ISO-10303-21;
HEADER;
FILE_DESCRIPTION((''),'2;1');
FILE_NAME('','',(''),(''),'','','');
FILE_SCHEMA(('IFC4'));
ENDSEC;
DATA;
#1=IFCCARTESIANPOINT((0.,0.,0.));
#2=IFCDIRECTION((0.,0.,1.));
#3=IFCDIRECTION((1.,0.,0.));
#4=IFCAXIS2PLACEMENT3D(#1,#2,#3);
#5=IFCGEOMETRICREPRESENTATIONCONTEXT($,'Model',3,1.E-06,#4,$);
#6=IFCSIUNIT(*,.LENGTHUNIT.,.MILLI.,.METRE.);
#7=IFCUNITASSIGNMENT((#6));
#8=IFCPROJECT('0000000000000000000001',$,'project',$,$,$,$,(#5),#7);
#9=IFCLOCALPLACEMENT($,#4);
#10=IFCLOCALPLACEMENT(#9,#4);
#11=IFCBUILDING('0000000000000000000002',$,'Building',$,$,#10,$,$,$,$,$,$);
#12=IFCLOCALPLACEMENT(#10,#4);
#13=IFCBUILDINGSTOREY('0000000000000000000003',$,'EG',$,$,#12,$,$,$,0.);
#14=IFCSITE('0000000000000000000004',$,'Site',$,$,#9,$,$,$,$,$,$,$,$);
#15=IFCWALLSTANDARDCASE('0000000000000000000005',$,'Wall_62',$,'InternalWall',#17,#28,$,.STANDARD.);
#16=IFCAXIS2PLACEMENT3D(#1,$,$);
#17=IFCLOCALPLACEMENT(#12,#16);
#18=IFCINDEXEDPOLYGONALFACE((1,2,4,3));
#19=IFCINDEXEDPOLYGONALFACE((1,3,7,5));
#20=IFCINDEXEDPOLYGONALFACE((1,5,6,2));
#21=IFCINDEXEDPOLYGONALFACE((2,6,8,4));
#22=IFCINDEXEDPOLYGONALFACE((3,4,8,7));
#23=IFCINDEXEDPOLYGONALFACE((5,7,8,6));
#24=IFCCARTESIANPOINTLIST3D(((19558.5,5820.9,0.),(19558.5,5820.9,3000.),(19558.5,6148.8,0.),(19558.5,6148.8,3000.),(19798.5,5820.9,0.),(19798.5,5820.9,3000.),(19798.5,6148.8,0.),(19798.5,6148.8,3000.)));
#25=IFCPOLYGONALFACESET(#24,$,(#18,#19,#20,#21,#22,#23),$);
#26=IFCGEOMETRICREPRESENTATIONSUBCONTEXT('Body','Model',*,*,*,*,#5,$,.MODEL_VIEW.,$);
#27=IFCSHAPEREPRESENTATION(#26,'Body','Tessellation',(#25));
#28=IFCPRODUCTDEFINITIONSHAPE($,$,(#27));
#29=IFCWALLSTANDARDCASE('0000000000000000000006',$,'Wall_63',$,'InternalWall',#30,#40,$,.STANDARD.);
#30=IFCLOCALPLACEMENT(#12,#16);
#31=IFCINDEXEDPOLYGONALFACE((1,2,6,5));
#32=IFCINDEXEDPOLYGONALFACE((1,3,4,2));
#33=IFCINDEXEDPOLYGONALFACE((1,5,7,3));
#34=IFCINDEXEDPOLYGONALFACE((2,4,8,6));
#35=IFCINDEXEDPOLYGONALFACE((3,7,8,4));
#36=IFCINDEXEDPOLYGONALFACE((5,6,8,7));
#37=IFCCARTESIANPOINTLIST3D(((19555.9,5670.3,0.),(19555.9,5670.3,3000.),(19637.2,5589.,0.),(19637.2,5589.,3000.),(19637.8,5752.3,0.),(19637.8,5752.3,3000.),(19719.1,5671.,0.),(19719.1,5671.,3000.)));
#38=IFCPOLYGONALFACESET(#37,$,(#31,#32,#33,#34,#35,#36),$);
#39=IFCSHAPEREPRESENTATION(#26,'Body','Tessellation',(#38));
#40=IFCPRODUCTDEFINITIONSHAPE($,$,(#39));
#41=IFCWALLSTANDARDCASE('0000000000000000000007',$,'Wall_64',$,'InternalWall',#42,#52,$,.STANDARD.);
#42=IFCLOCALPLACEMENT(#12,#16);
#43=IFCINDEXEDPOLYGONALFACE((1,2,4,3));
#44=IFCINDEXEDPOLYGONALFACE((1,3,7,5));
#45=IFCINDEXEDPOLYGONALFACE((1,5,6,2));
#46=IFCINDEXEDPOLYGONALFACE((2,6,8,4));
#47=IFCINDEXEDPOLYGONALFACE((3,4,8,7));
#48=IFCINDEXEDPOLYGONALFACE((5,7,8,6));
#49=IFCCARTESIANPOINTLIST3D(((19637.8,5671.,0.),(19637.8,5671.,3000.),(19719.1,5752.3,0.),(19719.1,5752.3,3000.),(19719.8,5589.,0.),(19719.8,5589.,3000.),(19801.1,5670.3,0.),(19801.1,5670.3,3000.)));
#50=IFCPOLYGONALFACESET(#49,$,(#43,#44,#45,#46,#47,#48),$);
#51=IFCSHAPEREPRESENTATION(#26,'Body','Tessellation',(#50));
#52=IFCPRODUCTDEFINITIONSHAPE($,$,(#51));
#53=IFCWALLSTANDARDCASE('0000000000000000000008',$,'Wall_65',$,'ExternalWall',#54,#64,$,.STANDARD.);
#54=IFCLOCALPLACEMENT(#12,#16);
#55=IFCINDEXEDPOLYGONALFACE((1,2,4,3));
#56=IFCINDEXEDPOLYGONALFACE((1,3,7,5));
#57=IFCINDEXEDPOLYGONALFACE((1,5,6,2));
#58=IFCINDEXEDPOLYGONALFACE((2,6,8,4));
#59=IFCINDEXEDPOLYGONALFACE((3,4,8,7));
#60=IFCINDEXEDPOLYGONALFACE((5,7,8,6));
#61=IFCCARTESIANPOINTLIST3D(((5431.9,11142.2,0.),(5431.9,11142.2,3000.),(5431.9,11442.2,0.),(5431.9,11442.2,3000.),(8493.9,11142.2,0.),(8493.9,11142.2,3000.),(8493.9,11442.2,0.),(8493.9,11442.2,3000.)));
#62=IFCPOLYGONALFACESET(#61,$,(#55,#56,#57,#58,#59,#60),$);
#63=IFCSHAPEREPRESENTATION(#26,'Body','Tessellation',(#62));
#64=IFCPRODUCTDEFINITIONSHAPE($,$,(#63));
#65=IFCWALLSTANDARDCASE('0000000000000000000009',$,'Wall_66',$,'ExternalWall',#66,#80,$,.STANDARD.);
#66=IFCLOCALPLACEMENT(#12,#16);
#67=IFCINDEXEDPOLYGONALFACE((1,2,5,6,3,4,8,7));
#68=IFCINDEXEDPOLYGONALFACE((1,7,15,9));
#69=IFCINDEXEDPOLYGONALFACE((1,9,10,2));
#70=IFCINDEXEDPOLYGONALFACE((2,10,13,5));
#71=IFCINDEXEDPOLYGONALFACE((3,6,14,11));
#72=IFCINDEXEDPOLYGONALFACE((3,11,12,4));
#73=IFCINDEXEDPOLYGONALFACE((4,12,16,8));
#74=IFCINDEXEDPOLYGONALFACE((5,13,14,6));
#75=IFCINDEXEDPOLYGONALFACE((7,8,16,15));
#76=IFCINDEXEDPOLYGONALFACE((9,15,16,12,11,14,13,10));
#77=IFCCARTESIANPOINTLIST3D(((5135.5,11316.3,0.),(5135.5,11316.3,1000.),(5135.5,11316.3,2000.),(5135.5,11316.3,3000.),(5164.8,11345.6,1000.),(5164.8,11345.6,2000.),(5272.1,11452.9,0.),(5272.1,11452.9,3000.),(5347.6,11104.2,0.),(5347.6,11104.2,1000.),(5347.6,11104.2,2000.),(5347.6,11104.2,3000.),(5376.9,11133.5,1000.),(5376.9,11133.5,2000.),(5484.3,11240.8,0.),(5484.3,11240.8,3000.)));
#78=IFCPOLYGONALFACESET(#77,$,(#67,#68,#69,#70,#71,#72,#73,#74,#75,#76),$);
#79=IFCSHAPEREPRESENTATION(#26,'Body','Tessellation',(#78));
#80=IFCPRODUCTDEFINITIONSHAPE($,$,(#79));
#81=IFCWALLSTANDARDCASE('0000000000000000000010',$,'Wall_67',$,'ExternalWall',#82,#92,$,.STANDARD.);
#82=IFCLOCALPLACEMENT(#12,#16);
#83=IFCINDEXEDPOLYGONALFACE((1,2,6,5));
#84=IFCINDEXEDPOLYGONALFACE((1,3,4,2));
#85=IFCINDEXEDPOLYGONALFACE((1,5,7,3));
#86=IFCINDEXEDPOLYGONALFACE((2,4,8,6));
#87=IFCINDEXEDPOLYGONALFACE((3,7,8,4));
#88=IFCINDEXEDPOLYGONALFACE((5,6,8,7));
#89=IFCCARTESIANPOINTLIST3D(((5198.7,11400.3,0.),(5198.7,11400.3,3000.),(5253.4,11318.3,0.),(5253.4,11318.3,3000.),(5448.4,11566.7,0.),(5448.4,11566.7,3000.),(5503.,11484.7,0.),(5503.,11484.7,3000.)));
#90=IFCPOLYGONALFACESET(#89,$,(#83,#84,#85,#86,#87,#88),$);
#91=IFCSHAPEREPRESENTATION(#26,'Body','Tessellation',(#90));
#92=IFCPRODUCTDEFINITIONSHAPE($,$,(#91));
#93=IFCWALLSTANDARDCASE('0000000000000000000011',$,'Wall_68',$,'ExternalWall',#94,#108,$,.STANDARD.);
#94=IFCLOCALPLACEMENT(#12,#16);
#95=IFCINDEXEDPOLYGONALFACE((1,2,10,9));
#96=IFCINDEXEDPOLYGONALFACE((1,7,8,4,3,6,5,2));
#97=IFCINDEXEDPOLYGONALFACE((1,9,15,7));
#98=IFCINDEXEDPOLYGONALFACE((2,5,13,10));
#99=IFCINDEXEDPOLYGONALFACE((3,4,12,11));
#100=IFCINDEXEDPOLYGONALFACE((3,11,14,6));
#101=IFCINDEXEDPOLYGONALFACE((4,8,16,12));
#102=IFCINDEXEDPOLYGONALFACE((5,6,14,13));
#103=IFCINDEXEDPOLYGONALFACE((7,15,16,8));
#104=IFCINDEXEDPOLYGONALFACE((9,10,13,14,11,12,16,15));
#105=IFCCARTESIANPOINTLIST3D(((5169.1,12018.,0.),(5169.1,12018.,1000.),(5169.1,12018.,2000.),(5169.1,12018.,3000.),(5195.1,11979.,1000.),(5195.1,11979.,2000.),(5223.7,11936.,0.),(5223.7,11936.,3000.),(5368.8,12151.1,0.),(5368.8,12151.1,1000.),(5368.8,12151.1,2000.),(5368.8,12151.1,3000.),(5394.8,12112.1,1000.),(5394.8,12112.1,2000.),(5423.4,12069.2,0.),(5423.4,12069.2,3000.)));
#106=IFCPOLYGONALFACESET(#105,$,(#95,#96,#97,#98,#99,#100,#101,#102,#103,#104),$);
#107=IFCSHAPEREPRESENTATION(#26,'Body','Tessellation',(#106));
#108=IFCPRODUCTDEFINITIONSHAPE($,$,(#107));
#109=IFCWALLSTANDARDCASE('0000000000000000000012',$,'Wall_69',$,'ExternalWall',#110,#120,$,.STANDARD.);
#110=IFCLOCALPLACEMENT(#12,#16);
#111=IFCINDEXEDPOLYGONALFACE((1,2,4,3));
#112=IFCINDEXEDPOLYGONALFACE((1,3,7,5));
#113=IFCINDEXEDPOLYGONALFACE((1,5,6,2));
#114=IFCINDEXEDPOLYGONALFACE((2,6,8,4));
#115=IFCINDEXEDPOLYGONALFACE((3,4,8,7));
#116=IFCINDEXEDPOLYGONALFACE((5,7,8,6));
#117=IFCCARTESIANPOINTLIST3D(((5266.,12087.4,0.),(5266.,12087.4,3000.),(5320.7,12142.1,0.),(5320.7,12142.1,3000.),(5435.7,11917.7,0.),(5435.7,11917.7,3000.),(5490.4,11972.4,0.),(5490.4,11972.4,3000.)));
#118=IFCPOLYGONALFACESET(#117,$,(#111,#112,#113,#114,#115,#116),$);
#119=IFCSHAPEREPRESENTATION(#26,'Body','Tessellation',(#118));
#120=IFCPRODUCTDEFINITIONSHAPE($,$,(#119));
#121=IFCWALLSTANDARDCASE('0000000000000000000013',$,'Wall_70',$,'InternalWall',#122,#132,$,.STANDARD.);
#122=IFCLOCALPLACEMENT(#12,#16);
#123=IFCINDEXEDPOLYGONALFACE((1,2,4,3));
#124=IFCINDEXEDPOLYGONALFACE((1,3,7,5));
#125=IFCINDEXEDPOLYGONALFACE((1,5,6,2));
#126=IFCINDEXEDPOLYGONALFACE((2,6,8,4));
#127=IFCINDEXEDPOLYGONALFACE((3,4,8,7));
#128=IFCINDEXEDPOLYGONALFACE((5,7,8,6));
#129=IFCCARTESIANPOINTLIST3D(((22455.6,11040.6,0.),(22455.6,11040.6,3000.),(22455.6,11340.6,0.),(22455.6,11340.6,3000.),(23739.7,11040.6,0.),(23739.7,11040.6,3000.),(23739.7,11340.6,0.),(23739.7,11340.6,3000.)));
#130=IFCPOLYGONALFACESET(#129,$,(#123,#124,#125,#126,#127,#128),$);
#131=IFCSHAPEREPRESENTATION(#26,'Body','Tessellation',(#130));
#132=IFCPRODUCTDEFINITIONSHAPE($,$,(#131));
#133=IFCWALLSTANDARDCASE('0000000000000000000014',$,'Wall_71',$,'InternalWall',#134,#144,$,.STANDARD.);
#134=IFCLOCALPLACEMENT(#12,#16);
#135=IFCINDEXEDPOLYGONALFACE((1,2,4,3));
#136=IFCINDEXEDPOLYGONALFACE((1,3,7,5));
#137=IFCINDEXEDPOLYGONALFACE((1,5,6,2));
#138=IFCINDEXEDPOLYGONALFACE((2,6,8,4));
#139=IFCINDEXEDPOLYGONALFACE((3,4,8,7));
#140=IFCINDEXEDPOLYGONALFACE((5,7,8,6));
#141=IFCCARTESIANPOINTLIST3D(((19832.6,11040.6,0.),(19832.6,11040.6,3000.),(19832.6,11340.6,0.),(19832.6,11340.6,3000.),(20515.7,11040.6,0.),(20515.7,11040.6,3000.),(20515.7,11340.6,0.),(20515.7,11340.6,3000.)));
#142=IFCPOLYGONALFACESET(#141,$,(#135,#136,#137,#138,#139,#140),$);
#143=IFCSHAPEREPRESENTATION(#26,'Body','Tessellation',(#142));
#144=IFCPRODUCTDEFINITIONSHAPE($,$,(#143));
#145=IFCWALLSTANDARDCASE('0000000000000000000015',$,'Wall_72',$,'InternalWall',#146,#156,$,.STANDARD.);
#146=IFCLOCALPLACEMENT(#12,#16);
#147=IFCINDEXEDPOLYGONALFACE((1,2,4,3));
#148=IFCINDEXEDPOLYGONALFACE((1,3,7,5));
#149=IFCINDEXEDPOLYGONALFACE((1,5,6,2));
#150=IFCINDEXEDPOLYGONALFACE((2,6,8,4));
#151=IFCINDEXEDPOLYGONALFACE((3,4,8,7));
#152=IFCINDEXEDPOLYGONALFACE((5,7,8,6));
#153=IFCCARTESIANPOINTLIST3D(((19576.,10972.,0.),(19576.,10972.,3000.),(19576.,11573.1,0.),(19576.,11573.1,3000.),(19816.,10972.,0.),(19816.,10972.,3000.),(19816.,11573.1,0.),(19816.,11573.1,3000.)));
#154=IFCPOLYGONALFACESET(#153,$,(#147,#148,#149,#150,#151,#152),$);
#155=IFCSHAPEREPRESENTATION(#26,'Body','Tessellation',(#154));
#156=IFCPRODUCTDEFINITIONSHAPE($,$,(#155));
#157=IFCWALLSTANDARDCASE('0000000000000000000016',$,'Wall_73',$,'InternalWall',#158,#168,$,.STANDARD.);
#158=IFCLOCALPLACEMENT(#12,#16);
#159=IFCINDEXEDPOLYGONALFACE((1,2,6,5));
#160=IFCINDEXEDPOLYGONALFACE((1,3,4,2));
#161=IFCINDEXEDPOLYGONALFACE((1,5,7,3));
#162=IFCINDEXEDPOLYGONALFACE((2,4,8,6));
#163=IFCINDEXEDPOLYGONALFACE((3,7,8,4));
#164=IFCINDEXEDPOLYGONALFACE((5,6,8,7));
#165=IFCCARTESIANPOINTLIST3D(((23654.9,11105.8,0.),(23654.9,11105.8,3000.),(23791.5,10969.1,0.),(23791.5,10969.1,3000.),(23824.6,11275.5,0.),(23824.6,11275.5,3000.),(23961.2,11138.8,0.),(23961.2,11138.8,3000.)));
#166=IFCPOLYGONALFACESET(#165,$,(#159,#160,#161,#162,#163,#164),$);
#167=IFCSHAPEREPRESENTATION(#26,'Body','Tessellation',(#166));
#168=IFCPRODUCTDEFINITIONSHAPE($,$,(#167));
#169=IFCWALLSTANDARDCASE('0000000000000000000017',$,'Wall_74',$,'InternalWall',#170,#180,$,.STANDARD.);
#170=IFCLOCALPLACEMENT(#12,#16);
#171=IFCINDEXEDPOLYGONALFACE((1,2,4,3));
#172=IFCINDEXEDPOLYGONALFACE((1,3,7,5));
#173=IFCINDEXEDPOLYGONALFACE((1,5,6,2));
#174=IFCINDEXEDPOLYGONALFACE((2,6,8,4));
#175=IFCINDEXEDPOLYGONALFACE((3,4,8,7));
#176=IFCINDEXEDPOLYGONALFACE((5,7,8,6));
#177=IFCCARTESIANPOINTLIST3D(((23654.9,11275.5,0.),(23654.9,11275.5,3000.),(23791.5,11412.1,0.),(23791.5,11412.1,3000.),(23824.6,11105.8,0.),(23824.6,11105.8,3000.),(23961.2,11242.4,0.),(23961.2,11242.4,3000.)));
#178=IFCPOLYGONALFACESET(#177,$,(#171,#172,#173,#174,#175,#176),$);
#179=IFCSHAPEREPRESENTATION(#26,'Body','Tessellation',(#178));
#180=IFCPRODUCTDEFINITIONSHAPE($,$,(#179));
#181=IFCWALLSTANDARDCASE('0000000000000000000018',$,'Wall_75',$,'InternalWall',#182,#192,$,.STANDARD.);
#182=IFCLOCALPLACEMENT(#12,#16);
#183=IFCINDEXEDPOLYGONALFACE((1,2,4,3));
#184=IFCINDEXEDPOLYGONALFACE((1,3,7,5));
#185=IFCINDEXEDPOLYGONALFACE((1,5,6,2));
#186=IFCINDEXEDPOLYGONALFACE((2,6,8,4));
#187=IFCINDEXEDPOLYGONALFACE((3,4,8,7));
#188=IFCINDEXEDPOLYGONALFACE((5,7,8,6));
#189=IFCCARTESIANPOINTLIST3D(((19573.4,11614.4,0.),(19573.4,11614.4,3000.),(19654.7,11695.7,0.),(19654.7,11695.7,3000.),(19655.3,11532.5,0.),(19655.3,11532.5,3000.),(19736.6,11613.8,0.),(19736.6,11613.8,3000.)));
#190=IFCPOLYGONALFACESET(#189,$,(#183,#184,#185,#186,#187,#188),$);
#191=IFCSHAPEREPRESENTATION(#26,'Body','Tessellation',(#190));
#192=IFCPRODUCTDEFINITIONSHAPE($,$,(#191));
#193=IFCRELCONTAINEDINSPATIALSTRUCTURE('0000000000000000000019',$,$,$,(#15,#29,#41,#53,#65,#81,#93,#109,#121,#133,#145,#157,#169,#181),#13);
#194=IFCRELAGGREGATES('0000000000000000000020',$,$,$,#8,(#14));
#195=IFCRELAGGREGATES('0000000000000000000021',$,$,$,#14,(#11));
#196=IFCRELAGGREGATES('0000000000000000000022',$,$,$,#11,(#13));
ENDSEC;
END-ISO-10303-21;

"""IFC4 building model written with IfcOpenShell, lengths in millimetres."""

from ifc_helpers import new_model, si_unit, frame, origin_with_axes, place, context, subcontext, project, spatial, rectangle, extrude, element, save


model = new_model("IFC4")

# Units and contexts
model_context = context("Model", 3, precision=1e-06, world=origin_with_axes())
body_context = subcontext(model_context, "Body", "Model", "MODEL_VIEW")
ifc_project = project(units=[si_unit("LENGTHUNIT", "METRE", prefix="MILLI")], contexts=[model_context])

# Site, building, storey
site_placement = place(None, origin_with_axes())
site = spatial("IfcSite", under=ifc_project, at=site_placement, Name="Site")
building_placement = place(site_placement, origin_with_axes())
building = spatial("IfcBuilding", under=site, at=building_placement, Name="Building")
storey_placement = place(building_placement, origin_with_axes())
storey = spatial("IfcBuildingStorey", under=building, at=storey_placement, Name="EG", Elevation=0.0)

# Walls
wall_1_placement = place(storey_placement, origin_with_axes())
element("IfcWallStandardCase", 1, at=wall_1_placement, inside=storey, Name="Wall_62", ObjectType="InternalWall", PredefinedType="STANDARD", context=body_context, shape_type="SweptSolid", body=[
    extrude(rectangle(XDim=327.9, YDim=240.0), frame((19678.5, 5984.8, 0.0), z_axis=(0.0, 0.0, 1.0), x_axis=(0.0, -1.0, 0.0)), (0.0, 0.0, 1.0), 3000.0),
])
wall_2_placement = place(storey_placement, origin_with_axes())
element("IfcWallStandardCase", 2, at=wall_2_placement, inside=storey, Name="Wall_63", ObjectType="InternalWall", PredefinedType="STANDARD", context=body_context, shape_type="SweptSolid", body=[
    extrude(rectangle(XDim=115.9, YDim=115.0), frame((19637.5, 5670.6, 0.0), z_axis=(0.0, 0.0, 1.0), x_axis=(-0.707107, -0.707107, 0.0)), (0.0, 0.0, 1.0), 3000.0),
])
wall_3_placement = place(storey_placement, origin_with_axes())
element("IfcWallStandardCase", 3, at=wall_3_placement, inside=storey, Name="Wall_64", ObjectType="InternalWall", PredefinedType="STANDARD", context=body_context, shape_type="SweptSolid", body=[
    extrude(rectangle(XDim=115.9, YDim=115.0), frame((19719.5, 5670.6, 0.0), z_axis=(0.0, 0.0, 1.0), x_axis=(0.707107, -0.707107, 0.0)), (0.0, 0.0, 1.0), 3000.0),
])
wall_4_placement = place(storey_placement, origin_with_axes())
element("IfcWallStandardCase", 4, at=wall_4_placement, inside=storey, Name="Wall_65", ObjectType="ExternalWall", PredefinedType="STANDARD", context=body_context, shape_type="SweptSolid", body=[
    extrude(rectangle(XDim=3062.1, YDim=300.0), frame((6962.9, 11292.2, 0.0), z_axis=(0.0, 0.0, 1.0), x_axis=(1.0, 0.0, 0.0)), (0.0, 0.0, 1.0), 3000.0),
])

# Wall, opening
wall_5_placement = place(storey_placement, origin_with_axes())
wall_5 = element("IfcWallStandardCase", 5, at=wall_5_placement, inside=storey, Name="Wall_66", ObjectType="ExternalWall", PredefinedType="STANDARD", context=body_context, shape_type="SweptSolid", body=[
    extrude(rectangle(XDim=193.2, YDim=300.0), frame((5309.9, 11278.6, 0.0), z_axis=(0.0, 0.0, 1.0), x_axis=(-0.707107, -0.707107, 0.0)), (0.0, 0.0, 1.0), 3000.0),
])
opening_1_placement = place(wall_5_placement, origin_with_axes())
element("IfcOpeningElement", 6, at=opening_1_placement, inside=storey, cuts=wall_5, context=body_context, shape_type="SweptSolid", body=[
    extrude(rectangle(XDim=626.1, YDim=300.0), frame((5049.5, 11018.2, 1000.0), z_axis=(0.0, 0.0, 1.0), x_axis=(-0.707107, -0.707107, 0.0)), (0.0, 0.0, 1.0), 1000.0),
])

# Wall
wall_6_placement = place(storey_placement, origin_with_axes())
element("IfcWallStandardCase", 7, at=wall_6_placement, inside=storey, Name="Wall_67", ObjectType="ExternalWall", PredefinedType="STANDARD", context=body_context, shape_type="SweptSolid", body=[
    extrude(rectangle(XDim=98.5, YDim=300.0), frame((5350.9, 11442.5, 0.0), z_axis=(0.0, 0.0, 1.0), x_axis=(0.5547, -0.83205, 0.0)), (0.0, 0.0, 1.0), 3000.0),
])

# Wall, opening
wall_7_placement = place(storey_placement, origin_with_axes())
wall_7 = element("IfcWallStandardCase", 8, at=wall_7_placement, inside=storey, Name="Wall_68", ObjectType="ExternalWall", PredefinedType="STANDARD", context=body_context, shape_type="SweptSolid", body=[
    extrude(rectangle(XDim=98.5, YDim=240.0), frame((5296.2, 12043.6, 0.0), z_axis=(0.0, 0.0, 1.0), x_axis=(-0.5547, 0.83205, 0.0)), (0.0, 0.0, 1.0), 3000.0),
])
opening_2_placement = place(wall_7_placement, origin_with_axes())
element("IfcOpeningElement", 9, at=opening_2_placement, inside=storey, cuts=wall_7, context=body_context, shape_type="SweptSolid", body=[
    extrude(rectangle(XDim=2549.6, YDim=240.0), frame((4587.8, 13106.3, 1000.0), z_axis=(0.0, 0.0, 1.0), x_axis=(-0.5547, 0.83205, 0.0)), (0.0, 0.0, 1.0), 1000.0),
])

# Walls
wall_8_placement = place(storey_placement, origin_with_axes())
element("IfcWallStandardCase", 10, at=wall_8_placement, inside=storey, Name="Wall_69", ObjectType="ExternalWall", PredefinedType="STANDARD", context=body_context, shape_type="SweptSolid", body=[
    extrude(rectangle(XDim=77.3, YDim=240.0), frame((5378.2, 12029.9, 0.0), z_axis=(0.0, 0.0, 1.0), x_axis=(0.707107, 0.707107, 0.0)), (0.0, 0.0, 1.0), 3000.0),
])
wall_9_placement = place(storey_placement, origin_with_axes())
element("IfcWallStandardCase", 11, at=wall_9_placement, inside=storey, Name="Wall_70", ObjectType="InternalWall", PredefinedType="STANDARD", context=body_context, shape_type="SweptSolid", body=[
    extrude(rectangle(XDim=1284.2, YDim=300.0), frame((23097.6, 11190.6, 0.0), z_axis=(0.0, 0.0, 1.0), x_axis=(-1.0, 0.0, 0.0)), (0.0, 0.0, 1.0), 3000.0),
])
wall_10_placement = place(storey_placement, origin_with_axes())
element("IfcWallStandardCase", 12, at=wall_10_placement, inside=storey, Name="Wall_71", ObjectType="InternalWall", PredefinedType="STANDARD", context=body_context, shape_type="SweptSolid", body=[
    extrude(rectangle(XDim=683.1, YDim=300.0), frame((20174.1, 11190.6, 0.0), z_axis=(0.0, 0.0, 1.0), x_axis=(-1.0, 0.0, 0.0)), (0.0, 0.0, 1.0), 3000.0),
])
wall_11_placement = place(storey_placement, origin_with_axes())
element("IfcWallStandardCase", 13, at=wall_11_placement, inside=storey, Name="Wall_72", ObjectType="InternalWall", PredefinedType="STANDARD", context=body_context, shape_type="SweptSolid", body=[
    extrude(rectangle(XDim=601.1, YDim=240.0), frame((19696.0, 11272.6, 0.0), z_axis=(0.0, 0.0, 1.0), x_axis=(0.0, -1.0, 0.0)), (0.0, 0.0, 1.0), 3000.0),
])
wall_12_placement = place(storey_placement, origin_with_axes())
element("IfcWallStandardCase", 14, at=wall_12_placement, inside=storey, Name="Wall_73", ObjectType="InternalWall", PredefinedType="STANDARD", context=body_context, shape_type="SweptSolid", body=[
    extrude(rectangle(XDim=193.2, YDim=240.0), frame((23808.0, 11122.3, 0.0), z_axis=(0.0, 0.0, 1.0), x_axis=(0.707107, -0.707107, 0.0)), (0.0, 0.0, 1.0), 3000.0),
])
wall_13_placement = place(storey_placement, origin_with_axes())
element("IfcWallStandardCase", 15, at=wall_13_placement, inside=storey, Name="Wall_74", ObjectType="InternalWall", PredefinedType="STANDARD", context=body_context, shape_type="SweptSolid", body=[
    extrude(rectangle(XDim=193.2, YDim=240.0), frame((23808.0, 11258.9, 0.0), z_axis=(0.0, 0.0, 1.0), x_axis=(0.707107, 0.707107, 0.0)), (0.0, 0.0, 1.0), 3000.0),
])
wall_14_placement = place(storey_placement, origin_with_axes())
element("IfcWallStandardCase", 16, at=wall_14_placement, inside=storey, Name="Wall_75", ObjectType="InternalWall", PredefinedType="STANDARD", context=body_context, shape_type="SweptSolid", body=[
    extrude(rectangle(XDim=115.9, YDim=115.0), frame((19655.0, 11614.1, 0.0), z_axis=(0.0, 0.0, 1.0), x_axis=(-0.707107, 0.707107, 0.0)), (0.0, 0.0, 1.0), 3000.0),
])

save(model, "model.ifc")
